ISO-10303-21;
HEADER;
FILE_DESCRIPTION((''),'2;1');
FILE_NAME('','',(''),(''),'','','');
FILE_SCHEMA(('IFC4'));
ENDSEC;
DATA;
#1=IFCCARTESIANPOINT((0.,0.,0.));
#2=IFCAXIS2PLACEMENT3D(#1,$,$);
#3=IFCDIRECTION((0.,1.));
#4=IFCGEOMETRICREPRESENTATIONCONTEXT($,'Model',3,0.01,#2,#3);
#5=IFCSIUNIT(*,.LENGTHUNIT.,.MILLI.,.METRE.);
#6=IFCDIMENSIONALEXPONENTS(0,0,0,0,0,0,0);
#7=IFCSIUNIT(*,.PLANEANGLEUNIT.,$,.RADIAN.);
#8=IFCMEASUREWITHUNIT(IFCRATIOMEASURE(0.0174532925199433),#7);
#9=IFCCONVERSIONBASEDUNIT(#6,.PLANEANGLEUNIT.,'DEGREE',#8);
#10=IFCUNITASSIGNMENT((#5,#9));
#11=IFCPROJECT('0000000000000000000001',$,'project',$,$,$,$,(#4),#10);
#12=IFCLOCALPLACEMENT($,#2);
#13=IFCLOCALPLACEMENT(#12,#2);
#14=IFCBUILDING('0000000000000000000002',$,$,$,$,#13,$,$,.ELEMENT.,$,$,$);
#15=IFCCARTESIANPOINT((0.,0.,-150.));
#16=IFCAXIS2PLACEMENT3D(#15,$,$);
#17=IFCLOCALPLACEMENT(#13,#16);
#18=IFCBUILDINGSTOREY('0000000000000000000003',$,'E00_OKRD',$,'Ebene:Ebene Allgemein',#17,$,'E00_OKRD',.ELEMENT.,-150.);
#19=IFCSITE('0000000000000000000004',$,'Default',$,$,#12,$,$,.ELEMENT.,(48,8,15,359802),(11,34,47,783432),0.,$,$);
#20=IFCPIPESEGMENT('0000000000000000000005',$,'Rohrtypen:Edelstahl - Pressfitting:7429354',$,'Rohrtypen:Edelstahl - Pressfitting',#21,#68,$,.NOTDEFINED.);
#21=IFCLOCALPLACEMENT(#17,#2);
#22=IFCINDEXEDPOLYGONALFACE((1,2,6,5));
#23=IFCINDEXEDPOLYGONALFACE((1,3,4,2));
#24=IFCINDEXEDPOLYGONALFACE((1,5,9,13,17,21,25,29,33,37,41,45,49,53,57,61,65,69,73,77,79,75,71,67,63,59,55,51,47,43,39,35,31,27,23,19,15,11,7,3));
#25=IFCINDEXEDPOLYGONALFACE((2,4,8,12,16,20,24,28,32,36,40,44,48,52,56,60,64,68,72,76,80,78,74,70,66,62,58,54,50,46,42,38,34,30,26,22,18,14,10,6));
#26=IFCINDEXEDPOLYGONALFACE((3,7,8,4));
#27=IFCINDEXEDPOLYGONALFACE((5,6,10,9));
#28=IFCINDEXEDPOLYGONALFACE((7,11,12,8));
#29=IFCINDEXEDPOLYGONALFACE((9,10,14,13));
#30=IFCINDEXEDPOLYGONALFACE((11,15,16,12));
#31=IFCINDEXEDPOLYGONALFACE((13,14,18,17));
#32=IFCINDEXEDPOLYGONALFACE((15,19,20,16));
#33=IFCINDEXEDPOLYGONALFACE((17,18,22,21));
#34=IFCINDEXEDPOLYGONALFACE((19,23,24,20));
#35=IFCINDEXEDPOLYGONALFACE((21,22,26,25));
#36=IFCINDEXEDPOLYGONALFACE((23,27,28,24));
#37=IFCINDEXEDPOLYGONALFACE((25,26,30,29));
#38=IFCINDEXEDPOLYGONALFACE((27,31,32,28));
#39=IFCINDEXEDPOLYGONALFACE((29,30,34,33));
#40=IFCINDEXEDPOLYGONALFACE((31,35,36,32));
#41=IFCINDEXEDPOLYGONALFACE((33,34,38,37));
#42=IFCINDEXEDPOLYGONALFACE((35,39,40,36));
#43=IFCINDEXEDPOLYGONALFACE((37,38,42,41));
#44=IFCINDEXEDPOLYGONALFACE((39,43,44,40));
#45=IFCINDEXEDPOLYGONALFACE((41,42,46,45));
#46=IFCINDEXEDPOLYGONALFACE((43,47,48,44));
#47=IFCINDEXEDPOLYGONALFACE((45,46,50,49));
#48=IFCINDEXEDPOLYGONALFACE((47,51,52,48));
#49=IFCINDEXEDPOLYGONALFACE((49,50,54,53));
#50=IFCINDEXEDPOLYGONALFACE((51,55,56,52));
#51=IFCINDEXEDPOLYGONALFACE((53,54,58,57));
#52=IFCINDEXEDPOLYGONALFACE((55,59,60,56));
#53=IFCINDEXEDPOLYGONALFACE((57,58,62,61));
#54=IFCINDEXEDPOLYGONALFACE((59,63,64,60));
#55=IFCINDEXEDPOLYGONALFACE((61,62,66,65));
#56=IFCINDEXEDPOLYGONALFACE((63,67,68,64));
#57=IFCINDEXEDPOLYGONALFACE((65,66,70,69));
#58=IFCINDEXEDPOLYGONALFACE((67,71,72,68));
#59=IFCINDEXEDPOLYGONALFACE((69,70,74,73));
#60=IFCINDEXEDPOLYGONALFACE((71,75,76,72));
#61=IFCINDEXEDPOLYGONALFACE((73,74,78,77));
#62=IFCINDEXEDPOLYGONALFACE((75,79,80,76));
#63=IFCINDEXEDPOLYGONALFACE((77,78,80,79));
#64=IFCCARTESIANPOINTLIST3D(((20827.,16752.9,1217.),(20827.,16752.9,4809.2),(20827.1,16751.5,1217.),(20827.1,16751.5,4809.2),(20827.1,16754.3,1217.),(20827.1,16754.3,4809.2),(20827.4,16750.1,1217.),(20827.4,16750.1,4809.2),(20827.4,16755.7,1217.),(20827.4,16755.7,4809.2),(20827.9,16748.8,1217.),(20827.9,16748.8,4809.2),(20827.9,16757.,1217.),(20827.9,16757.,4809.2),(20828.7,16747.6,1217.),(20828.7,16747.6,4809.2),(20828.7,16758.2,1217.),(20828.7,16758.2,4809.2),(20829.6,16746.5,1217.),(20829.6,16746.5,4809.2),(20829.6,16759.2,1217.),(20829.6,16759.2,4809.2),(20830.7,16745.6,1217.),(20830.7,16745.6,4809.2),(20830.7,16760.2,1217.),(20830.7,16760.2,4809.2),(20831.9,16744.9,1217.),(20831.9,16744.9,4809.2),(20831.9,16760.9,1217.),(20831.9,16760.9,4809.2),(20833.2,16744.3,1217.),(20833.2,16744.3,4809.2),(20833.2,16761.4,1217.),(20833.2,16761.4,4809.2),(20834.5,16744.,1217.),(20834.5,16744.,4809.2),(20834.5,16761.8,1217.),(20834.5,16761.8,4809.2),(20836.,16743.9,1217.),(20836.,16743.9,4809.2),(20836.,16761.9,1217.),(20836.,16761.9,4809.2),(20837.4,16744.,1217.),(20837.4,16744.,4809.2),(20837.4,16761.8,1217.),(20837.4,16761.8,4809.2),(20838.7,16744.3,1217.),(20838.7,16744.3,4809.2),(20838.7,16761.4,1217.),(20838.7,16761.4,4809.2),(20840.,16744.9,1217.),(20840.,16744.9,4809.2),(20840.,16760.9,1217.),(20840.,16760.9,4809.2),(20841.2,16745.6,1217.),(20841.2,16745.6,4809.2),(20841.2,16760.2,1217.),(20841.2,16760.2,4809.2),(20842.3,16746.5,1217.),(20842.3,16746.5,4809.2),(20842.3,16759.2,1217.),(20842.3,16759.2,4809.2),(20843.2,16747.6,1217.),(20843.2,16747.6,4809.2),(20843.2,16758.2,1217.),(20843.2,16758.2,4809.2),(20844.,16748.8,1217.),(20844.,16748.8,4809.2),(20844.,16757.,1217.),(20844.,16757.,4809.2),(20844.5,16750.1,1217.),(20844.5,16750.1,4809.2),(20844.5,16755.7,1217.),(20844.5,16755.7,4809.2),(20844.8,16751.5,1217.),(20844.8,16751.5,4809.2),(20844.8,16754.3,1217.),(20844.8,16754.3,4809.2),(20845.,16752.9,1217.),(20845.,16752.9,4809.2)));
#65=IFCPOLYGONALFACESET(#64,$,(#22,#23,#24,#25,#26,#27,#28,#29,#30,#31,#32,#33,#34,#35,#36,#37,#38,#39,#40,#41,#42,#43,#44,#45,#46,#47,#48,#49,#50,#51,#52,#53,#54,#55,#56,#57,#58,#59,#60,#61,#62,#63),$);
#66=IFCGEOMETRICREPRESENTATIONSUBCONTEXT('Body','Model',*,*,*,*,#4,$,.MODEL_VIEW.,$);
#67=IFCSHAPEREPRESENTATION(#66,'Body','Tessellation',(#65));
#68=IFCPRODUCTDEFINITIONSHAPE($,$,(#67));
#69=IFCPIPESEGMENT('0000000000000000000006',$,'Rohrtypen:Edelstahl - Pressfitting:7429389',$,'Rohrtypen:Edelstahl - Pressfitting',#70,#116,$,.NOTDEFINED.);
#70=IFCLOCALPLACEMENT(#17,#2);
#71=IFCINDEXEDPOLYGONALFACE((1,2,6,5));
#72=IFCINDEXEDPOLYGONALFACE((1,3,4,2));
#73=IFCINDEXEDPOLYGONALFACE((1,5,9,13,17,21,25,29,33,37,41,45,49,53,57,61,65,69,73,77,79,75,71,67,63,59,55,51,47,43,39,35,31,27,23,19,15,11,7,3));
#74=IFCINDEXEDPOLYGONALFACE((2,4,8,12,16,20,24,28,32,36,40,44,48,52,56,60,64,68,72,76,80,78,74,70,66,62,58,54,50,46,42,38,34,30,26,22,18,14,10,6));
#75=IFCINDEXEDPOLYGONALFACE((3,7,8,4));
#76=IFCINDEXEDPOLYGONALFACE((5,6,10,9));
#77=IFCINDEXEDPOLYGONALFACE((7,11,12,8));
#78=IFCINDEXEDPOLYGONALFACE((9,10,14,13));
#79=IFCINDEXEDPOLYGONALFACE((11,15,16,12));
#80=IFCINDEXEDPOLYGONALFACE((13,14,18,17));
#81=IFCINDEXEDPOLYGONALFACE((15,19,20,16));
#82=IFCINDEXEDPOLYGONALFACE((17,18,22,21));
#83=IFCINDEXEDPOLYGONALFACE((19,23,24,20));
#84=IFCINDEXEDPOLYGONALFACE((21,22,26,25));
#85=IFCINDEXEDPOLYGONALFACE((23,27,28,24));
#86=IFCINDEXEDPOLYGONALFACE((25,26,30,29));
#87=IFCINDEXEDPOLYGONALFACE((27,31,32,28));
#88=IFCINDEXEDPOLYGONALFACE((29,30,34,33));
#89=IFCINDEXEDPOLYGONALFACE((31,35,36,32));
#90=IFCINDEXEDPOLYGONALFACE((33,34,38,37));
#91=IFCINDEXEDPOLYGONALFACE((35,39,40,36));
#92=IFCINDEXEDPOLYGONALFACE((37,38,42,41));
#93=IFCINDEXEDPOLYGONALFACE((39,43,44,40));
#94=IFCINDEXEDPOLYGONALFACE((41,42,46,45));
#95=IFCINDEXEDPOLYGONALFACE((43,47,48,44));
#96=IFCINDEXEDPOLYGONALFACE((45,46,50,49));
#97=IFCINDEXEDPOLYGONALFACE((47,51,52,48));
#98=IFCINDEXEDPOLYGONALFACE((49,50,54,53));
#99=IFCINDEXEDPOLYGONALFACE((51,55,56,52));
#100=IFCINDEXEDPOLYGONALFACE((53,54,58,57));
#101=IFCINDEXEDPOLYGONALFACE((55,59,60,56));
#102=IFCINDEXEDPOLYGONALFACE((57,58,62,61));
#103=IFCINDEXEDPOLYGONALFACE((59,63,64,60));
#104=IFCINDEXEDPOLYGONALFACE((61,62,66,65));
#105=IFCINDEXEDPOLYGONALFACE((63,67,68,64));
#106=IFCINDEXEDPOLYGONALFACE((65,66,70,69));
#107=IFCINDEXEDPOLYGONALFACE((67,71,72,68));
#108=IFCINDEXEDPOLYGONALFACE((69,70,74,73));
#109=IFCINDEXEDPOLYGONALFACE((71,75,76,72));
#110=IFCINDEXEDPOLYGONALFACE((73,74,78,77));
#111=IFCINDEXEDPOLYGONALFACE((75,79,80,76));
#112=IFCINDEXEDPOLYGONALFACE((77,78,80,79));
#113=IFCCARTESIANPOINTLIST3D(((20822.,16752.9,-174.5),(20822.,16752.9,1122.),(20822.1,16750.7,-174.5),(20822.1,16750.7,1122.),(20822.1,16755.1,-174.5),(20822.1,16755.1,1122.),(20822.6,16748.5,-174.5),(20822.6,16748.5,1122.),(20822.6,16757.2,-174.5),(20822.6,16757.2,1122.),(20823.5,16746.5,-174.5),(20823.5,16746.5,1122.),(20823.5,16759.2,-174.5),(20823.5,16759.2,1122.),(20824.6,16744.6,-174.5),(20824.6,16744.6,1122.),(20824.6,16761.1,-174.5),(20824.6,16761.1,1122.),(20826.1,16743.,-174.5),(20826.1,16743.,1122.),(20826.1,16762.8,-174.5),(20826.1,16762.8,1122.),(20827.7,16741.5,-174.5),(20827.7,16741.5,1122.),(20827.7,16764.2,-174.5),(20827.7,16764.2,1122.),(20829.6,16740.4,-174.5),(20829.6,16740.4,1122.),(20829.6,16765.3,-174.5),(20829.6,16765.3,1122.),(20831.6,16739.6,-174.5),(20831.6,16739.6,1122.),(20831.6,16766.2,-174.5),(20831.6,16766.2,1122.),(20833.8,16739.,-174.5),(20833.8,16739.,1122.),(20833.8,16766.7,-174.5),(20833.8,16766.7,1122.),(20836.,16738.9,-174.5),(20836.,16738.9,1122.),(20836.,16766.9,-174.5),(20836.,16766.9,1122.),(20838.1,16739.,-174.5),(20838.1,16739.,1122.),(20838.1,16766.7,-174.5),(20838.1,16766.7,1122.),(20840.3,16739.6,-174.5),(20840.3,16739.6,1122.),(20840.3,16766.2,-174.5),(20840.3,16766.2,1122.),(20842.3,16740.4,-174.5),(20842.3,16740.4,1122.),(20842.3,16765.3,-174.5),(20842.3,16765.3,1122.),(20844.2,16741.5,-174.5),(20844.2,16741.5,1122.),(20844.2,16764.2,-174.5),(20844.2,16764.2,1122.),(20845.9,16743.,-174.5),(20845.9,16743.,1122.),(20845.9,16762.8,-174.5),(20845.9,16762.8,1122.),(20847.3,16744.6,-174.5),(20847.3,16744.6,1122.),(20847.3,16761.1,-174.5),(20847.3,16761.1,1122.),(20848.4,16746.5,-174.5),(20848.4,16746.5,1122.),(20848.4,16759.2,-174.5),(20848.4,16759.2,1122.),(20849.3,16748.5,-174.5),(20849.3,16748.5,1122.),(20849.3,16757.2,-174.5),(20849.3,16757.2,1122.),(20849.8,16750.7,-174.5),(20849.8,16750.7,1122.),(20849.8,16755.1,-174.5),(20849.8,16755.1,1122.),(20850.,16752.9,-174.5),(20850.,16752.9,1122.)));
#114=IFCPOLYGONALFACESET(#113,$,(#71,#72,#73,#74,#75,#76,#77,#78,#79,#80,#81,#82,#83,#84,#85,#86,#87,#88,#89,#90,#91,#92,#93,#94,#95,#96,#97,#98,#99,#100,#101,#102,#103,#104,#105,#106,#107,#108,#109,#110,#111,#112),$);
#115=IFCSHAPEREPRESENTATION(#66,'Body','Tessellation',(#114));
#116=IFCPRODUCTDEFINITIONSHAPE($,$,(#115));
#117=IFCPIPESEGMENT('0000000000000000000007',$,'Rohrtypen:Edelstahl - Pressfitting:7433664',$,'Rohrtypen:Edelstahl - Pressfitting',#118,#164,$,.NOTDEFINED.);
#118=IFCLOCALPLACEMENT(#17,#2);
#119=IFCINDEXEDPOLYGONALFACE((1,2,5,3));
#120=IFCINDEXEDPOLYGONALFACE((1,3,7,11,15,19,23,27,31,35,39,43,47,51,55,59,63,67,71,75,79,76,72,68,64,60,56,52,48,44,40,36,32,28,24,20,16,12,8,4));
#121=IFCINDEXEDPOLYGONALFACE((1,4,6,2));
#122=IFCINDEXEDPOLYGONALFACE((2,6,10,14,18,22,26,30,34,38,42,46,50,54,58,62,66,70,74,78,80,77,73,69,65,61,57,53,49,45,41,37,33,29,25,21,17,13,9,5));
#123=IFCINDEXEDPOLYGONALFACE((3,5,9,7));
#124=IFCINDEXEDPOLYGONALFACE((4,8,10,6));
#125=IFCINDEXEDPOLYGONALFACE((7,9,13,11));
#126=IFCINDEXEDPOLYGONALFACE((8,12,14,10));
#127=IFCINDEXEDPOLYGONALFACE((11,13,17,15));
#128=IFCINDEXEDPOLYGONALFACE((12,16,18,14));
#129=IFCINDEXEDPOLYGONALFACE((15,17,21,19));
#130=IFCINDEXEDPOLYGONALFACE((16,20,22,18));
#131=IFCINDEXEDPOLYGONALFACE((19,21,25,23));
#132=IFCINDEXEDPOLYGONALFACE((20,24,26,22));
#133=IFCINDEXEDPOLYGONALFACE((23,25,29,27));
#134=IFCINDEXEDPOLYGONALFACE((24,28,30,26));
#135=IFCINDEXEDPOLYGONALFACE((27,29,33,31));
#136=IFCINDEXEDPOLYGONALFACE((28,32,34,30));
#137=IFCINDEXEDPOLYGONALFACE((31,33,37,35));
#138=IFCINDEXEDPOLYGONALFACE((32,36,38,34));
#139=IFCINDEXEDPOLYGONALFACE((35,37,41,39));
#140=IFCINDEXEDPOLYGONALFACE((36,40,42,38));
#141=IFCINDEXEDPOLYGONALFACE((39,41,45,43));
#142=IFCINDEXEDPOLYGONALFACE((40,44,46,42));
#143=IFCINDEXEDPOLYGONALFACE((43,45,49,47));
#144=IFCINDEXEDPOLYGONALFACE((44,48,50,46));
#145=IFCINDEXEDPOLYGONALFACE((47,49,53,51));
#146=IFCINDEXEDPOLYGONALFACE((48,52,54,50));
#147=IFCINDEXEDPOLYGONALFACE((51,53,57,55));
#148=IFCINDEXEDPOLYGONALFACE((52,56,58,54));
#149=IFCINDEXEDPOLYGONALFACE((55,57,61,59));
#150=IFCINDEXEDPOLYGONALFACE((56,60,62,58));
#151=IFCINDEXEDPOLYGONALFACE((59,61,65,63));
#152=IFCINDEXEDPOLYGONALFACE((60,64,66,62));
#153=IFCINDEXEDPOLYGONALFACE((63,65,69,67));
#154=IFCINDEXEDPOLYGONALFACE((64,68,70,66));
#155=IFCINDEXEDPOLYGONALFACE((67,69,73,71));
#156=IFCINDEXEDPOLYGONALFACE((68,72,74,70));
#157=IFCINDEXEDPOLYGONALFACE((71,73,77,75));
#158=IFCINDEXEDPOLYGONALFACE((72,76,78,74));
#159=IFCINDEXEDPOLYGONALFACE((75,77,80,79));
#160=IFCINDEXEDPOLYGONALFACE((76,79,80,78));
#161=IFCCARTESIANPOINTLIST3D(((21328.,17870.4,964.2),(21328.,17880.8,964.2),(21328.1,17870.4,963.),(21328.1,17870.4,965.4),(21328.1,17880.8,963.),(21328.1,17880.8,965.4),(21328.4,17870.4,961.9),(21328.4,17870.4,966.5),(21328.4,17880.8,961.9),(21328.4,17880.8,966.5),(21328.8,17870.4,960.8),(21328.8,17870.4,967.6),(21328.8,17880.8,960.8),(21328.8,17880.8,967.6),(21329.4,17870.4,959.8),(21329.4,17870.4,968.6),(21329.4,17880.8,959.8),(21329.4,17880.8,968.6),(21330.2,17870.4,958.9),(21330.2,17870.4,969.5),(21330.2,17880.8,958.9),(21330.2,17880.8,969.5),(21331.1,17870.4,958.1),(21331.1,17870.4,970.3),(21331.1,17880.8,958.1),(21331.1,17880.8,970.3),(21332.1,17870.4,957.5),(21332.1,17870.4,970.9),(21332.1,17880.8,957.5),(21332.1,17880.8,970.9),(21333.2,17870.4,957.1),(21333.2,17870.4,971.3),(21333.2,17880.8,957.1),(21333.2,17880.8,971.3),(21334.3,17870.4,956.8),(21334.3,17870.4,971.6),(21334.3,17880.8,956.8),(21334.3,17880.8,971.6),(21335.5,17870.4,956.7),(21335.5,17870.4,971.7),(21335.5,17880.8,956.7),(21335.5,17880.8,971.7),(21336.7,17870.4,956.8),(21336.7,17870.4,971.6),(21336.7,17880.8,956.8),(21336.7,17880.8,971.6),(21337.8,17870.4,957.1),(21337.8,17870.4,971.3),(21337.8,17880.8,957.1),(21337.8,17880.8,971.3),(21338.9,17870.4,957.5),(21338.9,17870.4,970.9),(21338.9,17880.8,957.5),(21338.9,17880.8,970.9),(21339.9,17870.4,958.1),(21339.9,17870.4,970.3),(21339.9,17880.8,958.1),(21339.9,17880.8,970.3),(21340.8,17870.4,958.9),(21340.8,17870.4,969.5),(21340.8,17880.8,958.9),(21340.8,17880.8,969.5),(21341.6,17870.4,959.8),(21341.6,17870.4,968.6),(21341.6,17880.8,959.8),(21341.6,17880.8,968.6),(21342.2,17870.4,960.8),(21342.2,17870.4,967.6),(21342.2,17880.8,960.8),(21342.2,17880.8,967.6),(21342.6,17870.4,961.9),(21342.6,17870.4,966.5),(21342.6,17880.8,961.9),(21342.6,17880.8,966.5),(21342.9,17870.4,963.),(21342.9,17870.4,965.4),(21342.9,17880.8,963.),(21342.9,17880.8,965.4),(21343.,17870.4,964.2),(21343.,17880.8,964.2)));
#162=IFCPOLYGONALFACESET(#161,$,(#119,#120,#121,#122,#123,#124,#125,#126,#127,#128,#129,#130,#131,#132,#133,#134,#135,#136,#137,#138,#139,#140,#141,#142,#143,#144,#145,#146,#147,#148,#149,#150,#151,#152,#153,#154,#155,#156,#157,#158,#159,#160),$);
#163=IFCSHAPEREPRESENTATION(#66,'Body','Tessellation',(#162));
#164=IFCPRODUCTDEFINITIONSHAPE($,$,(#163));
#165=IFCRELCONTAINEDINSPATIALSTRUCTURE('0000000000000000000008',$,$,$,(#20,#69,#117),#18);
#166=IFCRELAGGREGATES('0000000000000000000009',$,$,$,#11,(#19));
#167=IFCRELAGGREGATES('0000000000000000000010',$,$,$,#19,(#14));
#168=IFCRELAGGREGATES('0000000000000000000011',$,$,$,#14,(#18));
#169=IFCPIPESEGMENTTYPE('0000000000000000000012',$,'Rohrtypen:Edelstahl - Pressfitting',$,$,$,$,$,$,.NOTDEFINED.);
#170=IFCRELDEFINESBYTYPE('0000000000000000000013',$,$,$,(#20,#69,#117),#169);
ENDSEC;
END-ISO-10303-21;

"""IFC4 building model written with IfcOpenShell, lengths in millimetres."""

from ifc_helpers import new_model, entity, si_unit, converted_unit, direction, frame, origin, place, context, subcontext, project, spatial, indexed_curve, outline, extrude, type_object, element, save


model = new_model("IFC4")

# Units and contexts
model_context = context("Model", 3, precision=0.01, world=origin(), true_north=direction((0.0, 1.0)))
body_context = subcontext(model_context, "Body", "Model", "MODEL_VIEW")
ifc_project = project(units=[si_unit("LENGTHUNIT", "METRE", prefix="MILLI"), converted_unit("PLANEANGLEUNIT", "DEGREE", entity("IfcRatioMeasure", 0.0174532925199433), si_unit("PLANEANGLEUNIT", "RADIAN"), dimensions=[0, 0, 0, 0, 0, 0, 0])], contexts=[model_context])

# Site, building, storey
site_placement = place(None, origin())
site = spatial("IfcSite", under=ifc_project, at=site_placement, Name="Default", CompositionType="ELEMENT", RefLatitude=(48, 8, 15, 359802), RefLongitude=(11, 34, 47, 783432), RefElevation=0.0)
building_placement = place(site_placement, origin())
building = spatial("IfcBuilding", under=site, at=building_placement, CompositionType="ELEMENT")
storey_placement = place(building_placement, frame((0.0, 0.0, -150.0)))
storey = spatial("IfcBuildingStorey", under=building, at=storey_placement, Name="E00_OKRD", ObjectType="Ebene:Ebene Allgemein", LongName="E00_OKRD", CompositionType="ELEMENT", Elevation=-150.0)

# Pipe segments
pipe_segment_type_1 = type_object("IfcPipeSegmentType", Name="Rohrtypen:Edelstahl - Pressfitting", PredefinedType="NOTDEFINED")
pipe_segment_1_placement = place(storey_placement, origin())
element("IfcPipeSegment", 1, at=pipe_segment_1_placement, inside=storey, type_object=pipe_segment_type_1, Name="Rohrtypen:Edelstahl - Pressfitting:7429354", ObjectType="Rohrtypen:Edelstahl - Pressfitting", PredefinedType="NOTDEFINED", context=body_context, shape_type="SweptSolid", body=[
    extrude(outline(indexed_curve([(9.0, 0.0), (8.9, 1.4), (8.6, 2.8), (8.0, 4.1), (7.3, 5.3), (6.4, 6.4), (5.3, 7.3), (4.1, 8.0), (2.8, 8.6), (1.4, 8.9), (0.0, 9.0), (-1.4, 8.9), (-2.8, 8.6), (-4.1, 8.0), (-5.3, 7.3), (-6.4, 6.4), (-7.3, 5.3), (-8.0, 4.1), (-8.6, 2.8), (-8.9, 1.4), (-9.0, 0.0), (-8.9, -1.4), (-8.6, -2.8), (-8.0, -4.1), (-7.3, -5.3), (-6.4, -6.4), (-5.3, -7.3), (-4.1, -8.0), (-2.8, -8.6), (-1.4, -8.9), (0.0, -9.0), (1.4, -8.9), (2.8, -8.6), (4.1, -8.0), (5.3, -7.3), (6.4, -6.4), (7.3, -5.3), (8.0, -4.1), (8.6, -2.8), (8.9, -1.4), (9.0, 0.0)], self_intersect=False)), frame((20836.0, 16752.9, 1217.0)), (0.0, 0.0, 1.0), 3592.2),
])
pipe_segment_2_placement = place(storey_placement, origin())
element("IfcPipeSegment", 2, at=pipe_segment_2_placement, inside=storey, type_object=pipe_segment_type_1, Name="Rohrtypen:Edelstahl - Pressfitting:7429389", ObjectType="Rohrtypen:Edelstahl - Pressfitting", PredefinedType="NOTDEFINED", context=body_context, shape_type="SweptSolid", body=[
    extrude(outline(indexed_curve([(14.0, 0.0), (13.8, 2.2), (13.3, 4.3), (12.5, 6.4), (11.3, 8.2), (9.9, 9.9), (8.2, 11.3), (6.4, 12.5), (4.3, 13.3), (2.2, 13.8), (0.0, 14.0), (-2.2, 13.8), (-4.3, 13.3), (-6.4, 12.5), (-8.2, 11.3), (-9.9, 9.9), (-11.3, 8.2), (-12.5, 6.4), (-13.3, 4.3), (-13.8, 2.2), (-14.0, 0.0), (-13.8, -2.2), (-13.3, -4.3), (-12.5, -6.4), (-11.3, -8.2), (-9.9, -9.9), (-8.2, -11.3), (-6.4, -12.5), (-4.3, -13.3), (-2.2, -13.8), (0.0, -14.0), (2.2, -13.8), (4.3, -13.3), (6.4, -12.5), (8.2, -11.3), (9.9, -9.9), (11.3, -8.2), (12.5, -6.4), (13.3, -4.3), (13.8, -2.2), (14.0, 0.0)], self_intersect=False)), frame((20836.0, 16752.9, -174.5)), (0.0, 0.0, 1.0), 1296.6),
])
pipe_segment_3_placement = place(storey_placement, origin())
element("IfcPipeSegment", 3, at=pipe_segment_3_placement, inside=storey, type_object=pipe_segment_type_1, Name="Rohrtypen:Edelstahl - Pressfitting:7433664", ObjectType="Rohrtypen:Edelstahl - Pressfitting", PredefinedType="NOTDEFINED", context=body_context, shape_type="SweptSolid", body=[
    extrude(outline(indexed_curve([(7.5, 0.0), (7.4, 1.2), (7.1, 2.3), (6.7, 3.4), (6.1, 4.4), (5.3, 5.3), (4.4, 6.1), (3.4, 6.7), (2.3, 7.1), (1.2, 7.4), (0.0, 7.5), (-1.2, 7.4), (-2.3, 7.1), (-3.4, 6.7), (-4.4, 6.1), (-5.3, 5.3), (-6.1, 4.4), (-6.7, 3.4), (-7.1, 2.3), (-7.4, 1.2), (-7.5, 0.0), (-7.4, -1.2), (-7.1, -2.3), (-6.7, -3.4), (-6.1, -4.4), (-5.3, -5.3), (-4.4, -6.1), (-3.4, -6.7), (-2.3, -7.1), (-1.2, -7.4), (0.0, -7.5), (1.2, -7.4), (2.3, -7.1), (3.4, -6.7), (4.4, -6.1), (5.3, -5.3), (6.1, -4.4), (6.7, -3.4), (7.1, -2.3), (7.4, -1.2), (7.5, 0.0)], self_intersect=False)), frame((21335.5, 17870.4, 964.2), z_axis=(0.0, 1.0, 0.0), x_axis=(-1.0, 0.0, 0.0)), (0.0, 0.0, 1.0), 10.4),
])

save(model, "model.ifc")
